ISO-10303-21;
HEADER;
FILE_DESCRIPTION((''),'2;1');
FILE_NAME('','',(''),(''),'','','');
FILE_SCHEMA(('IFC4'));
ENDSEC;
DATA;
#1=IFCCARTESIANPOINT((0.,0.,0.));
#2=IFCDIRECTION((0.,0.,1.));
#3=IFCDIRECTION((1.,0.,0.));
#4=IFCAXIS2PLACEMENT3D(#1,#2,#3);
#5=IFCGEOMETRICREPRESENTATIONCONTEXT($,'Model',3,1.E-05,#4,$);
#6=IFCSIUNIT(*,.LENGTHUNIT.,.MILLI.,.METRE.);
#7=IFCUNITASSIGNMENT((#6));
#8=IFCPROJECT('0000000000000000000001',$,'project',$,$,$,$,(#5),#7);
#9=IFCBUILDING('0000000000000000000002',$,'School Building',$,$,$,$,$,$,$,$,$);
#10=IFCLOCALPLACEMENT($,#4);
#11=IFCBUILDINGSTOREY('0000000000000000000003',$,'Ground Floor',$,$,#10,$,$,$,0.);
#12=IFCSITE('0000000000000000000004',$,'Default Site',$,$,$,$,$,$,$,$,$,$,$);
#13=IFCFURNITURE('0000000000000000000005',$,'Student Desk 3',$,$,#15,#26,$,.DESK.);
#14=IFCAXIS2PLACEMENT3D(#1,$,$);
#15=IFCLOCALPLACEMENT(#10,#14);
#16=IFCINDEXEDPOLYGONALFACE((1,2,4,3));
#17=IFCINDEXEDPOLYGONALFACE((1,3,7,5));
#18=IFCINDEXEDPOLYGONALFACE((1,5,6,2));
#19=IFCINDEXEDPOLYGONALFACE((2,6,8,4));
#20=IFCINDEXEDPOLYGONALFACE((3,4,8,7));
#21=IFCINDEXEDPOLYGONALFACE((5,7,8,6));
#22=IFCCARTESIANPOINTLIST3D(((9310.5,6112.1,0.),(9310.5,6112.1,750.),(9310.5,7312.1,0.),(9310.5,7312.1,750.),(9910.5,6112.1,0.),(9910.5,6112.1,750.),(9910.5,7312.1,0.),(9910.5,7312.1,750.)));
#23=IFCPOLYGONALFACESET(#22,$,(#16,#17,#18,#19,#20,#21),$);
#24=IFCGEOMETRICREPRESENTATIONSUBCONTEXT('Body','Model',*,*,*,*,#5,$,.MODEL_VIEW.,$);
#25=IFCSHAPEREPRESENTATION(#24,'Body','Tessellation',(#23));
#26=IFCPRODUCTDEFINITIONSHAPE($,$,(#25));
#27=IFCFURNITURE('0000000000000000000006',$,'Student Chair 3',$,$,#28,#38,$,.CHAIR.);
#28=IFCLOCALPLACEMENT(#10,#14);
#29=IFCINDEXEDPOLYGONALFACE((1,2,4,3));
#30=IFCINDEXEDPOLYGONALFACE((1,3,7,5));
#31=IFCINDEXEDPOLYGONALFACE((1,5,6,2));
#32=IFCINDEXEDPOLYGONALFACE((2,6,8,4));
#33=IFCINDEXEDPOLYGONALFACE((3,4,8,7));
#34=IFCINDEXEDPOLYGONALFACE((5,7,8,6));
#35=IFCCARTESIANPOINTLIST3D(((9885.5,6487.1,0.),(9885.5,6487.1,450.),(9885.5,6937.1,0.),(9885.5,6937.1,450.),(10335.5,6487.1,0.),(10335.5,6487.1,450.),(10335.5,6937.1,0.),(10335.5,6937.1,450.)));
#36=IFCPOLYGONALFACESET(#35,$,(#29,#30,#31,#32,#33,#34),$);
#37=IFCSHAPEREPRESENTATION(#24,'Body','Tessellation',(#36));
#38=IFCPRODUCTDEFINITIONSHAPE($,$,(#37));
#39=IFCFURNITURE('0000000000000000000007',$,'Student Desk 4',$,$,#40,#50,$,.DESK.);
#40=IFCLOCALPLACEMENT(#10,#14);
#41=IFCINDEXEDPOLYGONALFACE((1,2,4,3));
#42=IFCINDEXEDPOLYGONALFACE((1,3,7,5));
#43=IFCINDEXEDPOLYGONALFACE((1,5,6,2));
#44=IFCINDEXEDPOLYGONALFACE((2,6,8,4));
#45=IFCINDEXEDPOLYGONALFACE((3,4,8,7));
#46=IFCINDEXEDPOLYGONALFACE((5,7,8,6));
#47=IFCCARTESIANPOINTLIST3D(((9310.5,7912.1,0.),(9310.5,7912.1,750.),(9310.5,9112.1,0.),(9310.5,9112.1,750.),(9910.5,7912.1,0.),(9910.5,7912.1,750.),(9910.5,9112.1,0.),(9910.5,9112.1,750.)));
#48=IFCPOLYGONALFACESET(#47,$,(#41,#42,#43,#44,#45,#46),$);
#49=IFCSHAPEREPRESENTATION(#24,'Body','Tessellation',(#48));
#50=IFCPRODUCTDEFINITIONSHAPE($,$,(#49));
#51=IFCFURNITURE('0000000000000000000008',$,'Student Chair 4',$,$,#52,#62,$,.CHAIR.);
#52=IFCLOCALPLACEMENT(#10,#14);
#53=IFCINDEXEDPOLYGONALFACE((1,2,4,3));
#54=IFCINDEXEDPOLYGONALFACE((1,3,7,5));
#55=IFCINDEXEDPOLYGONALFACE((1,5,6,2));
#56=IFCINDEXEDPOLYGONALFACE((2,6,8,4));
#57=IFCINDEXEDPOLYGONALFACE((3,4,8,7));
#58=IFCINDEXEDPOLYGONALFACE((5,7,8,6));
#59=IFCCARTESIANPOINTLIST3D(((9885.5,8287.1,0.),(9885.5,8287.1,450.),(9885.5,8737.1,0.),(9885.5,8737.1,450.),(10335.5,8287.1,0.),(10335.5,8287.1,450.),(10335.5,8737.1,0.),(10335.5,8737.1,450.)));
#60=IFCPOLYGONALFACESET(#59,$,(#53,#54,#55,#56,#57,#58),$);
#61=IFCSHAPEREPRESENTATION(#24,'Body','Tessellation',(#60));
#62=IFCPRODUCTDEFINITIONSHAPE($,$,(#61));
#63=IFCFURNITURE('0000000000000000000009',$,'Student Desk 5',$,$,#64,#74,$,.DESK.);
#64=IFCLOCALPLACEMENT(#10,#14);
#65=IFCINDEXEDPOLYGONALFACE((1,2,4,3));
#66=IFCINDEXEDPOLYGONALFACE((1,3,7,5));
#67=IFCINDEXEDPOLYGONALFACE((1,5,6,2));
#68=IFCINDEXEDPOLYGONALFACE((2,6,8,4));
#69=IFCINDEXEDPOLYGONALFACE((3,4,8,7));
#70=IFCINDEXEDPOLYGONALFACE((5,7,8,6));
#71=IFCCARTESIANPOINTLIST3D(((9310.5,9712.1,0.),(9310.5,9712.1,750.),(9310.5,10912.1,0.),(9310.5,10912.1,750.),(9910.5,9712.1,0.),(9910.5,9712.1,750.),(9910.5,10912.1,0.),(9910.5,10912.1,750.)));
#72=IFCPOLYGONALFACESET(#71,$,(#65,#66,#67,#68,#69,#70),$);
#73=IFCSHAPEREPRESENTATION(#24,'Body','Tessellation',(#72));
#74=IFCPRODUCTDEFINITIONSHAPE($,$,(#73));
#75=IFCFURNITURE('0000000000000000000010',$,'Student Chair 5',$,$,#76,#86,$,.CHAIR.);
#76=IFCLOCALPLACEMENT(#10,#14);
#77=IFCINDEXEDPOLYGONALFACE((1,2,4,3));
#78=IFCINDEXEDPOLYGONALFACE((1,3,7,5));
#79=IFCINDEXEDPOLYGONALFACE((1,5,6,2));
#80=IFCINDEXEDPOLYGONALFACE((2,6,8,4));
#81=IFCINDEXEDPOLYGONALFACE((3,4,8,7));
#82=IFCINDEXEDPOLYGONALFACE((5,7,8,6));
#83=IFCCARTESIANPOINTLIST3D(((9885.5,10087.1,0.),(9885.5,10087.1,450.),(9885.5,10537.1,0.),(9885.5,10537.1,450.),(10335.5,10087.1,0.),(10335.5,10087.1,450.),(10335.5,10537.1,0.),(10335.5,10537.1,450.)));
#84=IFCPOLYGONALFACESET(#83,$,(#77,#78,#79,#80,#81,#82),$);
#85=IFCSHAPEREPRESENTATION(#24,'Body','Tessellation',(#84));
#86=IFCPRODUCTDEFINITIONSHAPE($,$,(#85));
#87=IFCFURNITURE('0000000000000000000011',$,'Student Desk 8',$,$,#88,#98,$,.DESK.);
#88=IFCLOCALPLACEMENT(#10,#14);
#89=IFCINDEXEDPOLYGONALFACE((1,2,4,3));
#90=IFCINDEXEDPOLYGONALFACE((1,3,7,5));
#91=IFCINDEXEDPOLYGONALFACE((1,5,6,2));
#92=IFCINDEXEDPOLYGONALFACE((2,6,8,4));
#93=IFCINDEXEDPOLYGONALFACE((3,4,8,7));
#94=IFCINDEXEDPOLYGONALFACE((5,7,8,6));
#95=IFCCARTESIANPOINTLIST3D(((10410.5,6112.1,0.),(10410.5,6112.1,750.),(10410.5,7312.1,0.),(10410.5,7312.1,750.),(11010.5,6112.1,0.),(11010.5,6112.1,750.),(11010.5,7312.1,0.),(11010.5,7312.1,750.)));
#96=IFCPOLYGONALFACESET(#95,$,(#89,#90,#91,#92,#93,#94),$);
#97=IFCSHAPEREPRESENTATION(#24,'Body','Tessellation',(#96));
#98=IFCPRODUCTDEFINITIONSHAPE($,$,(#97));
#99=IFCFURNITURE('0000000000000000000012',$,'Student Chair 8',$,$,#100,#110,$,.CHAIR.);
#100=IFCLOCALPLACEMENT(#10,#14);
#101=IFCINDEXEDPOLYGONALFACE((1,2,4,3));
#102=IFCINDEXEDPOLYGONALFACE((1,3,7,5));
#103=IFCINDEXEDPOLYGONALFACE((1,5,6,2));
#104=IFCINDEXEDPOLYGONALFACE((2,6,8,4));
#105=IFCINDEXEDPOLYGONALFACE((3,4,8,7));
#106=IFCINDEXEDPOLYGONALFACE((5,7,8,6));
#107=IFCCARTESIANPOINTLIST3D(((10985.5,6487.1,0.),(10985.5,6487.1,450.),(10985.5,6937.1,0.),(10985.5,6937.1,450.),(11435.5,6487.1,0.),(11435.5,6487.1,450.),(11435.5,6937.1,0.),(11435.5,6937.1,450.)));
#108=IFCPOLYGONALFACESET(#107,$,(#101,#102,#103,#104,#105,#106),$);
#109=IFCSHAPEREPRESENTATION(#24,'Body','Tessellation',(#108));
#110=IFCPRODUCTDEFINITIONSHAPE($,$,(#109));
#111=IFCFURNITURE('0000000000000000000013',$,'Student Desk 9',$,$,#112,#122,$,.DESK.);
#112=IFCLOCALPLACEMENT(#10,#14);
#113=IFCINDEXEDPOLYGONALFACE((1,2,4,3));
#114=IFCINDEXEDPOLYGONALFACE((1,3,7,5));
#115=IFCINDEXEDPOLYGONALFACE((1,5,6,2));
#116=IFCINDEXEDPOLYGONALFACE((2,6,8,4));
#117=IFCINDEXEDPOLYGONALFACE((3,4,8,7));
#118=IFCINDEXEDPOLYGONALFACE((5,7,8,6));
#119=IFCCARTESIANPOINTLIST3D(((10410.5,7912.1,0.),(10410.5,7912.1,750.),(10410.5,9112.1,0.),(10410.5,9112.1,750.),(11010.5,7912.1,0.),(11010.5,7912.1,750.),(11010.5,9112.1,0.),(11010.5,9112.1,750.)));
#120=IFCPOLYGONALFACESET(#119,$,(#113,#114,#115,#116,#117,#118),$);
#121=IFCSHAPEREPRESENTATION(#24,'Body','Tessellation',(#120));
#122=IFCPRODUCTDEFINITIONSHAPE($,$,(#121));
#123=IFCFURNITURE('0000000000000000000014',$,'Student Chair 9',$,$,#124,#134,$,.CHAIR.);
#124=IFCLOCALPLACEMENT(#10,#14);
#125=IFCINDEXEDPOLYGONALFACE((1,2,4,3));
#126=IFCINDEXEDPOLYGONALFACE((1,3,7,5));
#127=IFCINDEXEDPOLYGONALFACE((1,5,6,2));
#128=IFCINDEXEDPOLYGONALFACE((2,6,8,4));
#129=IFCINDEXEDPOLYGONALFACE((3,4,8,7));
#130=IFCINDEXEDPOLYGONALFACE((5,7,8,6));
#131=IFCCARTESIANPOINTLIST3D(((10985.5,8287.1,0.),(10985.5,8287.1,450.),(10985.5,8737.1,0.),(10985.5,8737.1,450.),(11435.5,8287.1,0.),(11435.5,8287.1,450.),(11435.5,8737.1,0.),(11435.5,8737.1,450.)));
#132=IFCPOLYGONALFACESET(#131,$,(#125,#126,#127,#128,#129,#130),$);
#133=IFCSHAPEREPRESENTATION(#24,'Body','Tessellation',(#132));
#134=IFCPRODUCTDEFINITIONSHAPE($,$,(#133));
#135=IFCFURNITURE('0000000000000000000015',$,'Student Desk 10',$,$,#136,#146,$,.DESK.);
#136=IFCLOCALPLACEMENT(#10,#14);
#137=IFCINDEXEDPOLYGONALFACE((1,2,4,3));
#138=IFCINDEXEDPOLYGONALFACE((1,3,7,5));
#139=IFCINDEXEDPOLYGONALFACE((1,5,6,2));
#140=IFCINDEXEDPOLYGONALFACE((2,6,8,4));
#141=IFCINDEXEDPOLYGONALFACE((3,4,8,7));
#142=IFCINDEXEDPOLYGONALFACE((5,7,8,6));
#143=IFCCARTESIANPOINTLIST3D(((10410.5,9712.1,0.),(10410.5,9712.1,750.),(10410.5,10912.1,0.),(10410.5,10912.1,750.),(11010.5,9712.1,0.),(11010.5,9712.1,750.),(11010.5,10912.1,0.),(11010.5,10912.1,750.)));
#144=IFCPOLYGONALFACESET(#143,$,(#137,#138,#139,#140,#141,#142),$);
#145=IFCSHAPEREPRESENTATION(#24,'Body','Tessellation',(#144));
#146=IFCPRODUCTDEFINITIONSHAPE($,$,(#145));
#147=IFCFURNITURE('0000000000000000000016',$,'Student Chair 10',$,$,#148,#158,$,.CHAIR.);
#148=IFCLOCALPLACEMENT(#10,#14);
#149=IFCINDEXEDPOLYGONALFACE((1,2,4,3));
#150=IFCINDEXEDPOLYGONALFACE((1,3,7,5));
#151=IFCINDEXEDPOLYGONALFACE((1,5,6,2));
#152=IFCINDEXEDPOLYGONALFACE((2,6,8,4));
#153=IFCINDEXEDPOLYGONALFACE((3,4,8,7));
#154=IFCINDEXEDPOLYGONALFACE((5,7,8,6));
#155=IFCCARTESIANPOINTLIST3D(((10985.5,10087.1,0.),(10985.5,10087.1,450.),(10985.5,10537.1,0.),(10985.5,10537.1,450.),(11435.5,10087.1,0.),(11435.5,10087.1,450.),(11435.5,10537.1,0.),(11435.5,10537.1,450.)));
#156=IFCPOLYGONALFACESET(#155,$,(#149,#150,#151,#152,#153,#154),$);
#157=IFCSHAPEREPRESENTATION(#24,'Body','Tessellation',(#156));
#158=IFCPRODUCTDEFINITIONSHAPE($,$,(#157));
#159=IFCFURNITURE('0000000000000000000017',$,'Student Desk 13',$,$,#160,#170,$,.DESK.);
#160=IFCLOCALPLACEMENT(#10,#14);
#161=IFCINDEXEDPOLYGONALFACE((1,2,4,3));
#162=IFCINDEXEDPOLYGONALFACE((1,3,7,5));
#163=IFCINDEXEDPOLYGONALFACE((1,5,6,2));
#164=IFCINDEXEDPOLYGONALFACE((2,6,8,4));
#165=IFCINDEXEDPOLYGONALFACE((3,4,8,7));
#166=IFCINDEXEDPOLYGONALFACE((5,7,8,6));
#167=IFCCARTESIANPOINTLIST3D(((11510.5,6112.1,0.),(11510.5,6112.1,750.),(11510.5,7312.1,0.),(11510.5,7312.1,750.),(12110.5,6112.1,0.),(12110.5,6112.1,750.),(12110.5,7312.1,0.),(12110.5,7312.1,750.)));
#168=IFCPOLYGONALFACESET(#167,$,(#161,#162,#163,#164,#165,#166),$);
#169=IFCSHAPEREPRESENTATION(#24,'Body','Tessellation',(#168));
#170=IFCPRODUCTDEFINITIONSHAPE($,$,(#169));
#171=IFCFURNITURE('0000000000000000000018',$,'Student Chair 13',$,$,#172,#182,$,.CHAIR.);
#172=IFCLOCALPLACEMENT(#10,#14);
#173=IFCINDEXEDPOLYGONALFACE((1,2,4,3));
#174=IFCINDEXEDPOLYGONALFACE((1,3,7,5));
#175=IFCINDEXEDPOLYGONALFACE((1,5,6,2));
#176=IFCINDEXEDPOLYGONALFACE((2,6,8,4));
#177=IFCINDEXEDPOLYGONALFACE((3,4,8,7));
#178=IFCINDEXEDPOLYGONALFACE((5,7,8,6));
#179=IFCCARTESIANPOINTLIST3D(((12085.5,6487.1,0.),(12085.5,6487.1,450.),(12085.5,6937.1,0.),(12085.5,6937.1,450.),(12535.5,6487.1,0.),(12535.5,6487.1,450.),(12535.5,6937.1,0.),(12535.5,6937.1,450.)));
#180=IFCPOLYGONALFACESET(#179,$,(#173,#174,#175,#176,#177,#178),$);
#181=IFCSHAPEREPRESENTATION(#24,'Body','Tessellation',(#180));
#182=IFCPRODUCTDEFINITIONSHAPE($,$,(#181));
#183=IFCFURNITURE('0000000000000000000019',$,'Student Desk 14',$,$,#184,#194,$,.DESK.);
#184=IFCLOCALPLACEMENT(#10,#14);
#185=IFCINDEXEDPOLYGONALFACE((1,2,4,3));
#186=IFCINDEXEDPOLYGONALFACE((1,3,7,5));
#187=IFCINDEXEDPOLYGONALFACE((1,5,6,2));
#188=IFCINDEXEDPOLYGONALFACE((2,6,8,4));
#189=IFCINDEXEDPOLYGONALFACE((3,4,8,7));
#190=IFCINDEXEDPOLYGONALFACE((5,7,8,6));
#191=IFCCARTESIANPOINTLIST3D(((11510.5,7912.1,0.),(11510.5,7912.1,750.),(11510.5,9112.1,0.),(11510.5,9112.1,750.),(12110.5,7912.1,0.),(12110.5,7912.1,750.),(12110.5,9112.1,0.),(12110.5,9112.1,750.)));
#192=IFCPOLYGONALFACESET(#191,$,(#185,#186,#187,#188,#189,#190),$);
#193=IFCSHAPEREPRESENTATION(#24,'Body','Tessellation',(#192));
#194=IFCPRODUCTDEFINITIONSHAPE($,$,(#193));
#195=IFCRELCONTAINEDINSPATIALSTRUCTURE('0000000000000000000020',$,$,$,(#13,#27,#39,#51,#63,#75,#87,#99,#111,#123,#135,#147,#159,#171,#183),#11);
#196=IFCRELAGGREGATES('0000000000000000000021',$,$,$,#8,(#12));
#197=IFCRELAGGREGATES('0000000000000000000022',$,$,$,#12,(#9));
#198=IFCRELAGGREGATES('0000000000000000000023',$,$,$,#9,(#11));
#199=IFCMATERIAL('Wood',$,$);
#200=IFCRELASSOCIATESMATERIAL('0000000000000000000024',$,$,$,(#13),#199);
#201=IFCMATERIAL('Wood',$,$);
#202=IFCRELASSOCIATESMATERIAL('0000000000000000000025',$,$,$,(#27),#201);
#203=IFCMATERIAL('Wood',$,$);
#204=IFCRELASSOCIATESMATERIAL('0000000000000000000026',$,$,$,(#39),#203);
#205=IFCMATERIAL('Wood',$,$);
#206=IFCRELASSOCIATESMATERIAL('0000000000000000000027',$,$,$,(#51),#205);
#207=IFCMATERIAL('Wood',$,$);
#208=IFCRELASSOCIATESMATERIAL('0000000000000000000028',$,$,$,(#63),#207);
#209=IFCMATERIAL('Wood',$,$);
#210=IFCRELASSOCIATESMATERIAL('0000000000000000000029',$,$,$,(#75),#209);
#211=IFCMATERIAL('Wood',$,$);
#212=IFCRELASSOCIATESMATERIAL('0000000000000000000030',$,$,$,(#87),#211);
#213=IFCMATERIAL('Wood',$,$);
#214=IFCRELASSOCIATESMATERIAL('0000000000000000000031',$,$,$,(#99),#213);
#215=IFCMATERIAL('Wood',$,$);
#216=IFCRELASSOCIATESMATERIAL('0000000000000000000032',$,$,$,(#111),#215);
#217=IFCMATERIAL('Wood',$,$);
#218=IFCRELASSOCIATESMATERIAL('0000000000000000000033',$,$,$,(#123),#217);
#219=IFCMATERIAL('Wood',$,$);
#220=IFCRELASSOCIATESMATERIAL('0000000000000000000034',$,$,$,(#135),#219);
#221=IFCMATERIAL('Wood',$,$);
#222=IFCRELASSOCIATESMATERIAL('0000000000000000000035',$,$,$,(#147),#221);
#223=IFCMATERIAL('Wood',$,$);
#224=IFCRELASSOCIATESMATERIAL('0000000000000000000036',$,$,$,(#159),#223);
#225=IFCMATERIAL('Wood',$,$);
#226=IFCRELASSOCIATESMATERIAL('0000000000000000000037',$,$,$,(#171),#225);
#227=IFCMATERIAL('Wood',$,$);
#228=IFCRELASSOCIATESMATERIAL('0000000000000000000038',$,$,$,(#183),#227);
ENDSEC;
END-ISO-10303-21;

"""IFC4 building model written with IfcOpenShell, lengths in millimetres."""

from ifc_helpers import new_model, si_unit, frame, origin_with_axes, origin_2d, place, context, subcontext, project, spatial, rectangle, extrude, material, element, save


model = new_model("IFC4")

# Units and contexts
model_context = context("Model", 3, precision=1e-05, world=origin_with_axes())
body_context = subcontext(model_context, "Body", "Model", "MODEL_VIEW")
ifc_project = project(units=[si_unit("LENGTHUNIT", "METRE", prefix="MILLI")], contexts=[model_context])

# Site, building, storey
site = spatial("IfcSite", under=ifc_project, Name="Default Site")
building = spatial("IfcBuilding", under=site, Name="School Building")
storey_placement = place(None, origin_with_axes())
storey = spatial("IfcBuildingStorey", under=building, at=storey_placement, Name="Ground Floor", Elevation=0.0)

# Furniture
ifc_material_1 = material(Name="Wood")
furniture_1_placement = place(storey_placement, frame((9610.5, 6712.1, 0.0), z_axis=(0.0, 0.0, 1.0), x_axis=(0.0, 1.0, 0.0)))
element("IfcFurniture", 1, at=furniture_1_placement, inside=storey, material=ifc_material_1, Name="Student Desk 3", PredefinedType="DESK", context=body_context, shape_type="SweptSolid", body=[
    extrude(rectangle(XDim=1200.0, YDim=600.0, at=origin_2d()), origin_with_axes(), (0.0, 0.0, 1.0), 750.0),
])
ifc_material_2 = material(Name="Wood")
furniture_2_placement = place(storey_placement, frame((10110.5, 6712.1, 0.0), z_axis=(0.0, 0.0, 1.0), x_axis=(1.0, 0.0, 0.0)))
element("IfcFurniture", 2, at=furniture_2_placement, inside=storey, material=ifc_material_2, Name="Student Chair 3", PredefinedType="CHAIR", context=body_context, shape_type="SweptSolid", body=[
    extrude(rectangle(XDim=450.0, YDim=450.0, at=origin_2d()), origin_with_axes(), (0.0, 0.0, 1.0), 450.0),
])
ifc_material_3 = material(Name="Wood")
furniture_3_placement = place(storey_placement, frame((9610.5, 8512.1, 0.0), z_axis=(0.0, 0.0, 1.0), x_axis=(0.0, 1.0, 0.0)))
element("IfcFurniture", 3, at=furniture_3_placement, inside=storey, material=ifc_material_3, Name="Student Desk 4", PredefinedType="DESK", context=body_context, shape_type="SweptSolid", body=[
    extrude(rectangle(XDim=1200.0, YDim=600.0, at=origin_2d()), origin_with_axes(), (0.0, 0.0, 1.0), 750.0),
])
ifc_material_4 = material(Name="Wood")
furniture_4_placement = place(storey_placement, frame((10110.5, 8512.1, 0.0), z_axis=(0.0, 0.0, 1.0), x_axis=(1.0, 0.0, 0.0)))
element("IfcFurniture", 4, at=furniture_4_placement, inside=storey, material=ifc_material_4, Name="Student Chair 4", PredefinedType="CHAIR", context=body_context, shape_type="SweptSolid", body=[
    extrude(rectangle(XDim=450.0, YDim=450.0, at=origin_2d()), origin_with_axes(), (0.0, 0.0, 1.0), 450.0),
])
ifc_material_5 = material(Name="Wood")
furniture_5_placement = place(storey_placement, frame((9610.5, 10312.1, 0.0), z_axis=(0.0, 0.0, 1.0), x_axis=(0.0, 1.0, 0.0)))
element("IfcFurniture", 5, at=furniture_5_placement, inside=storey, material=ifc_material_5, Name="Student Desk 5", PredefinedType="DESK", context=body_context, shape_type="SweptSolid", body=[
    extrude(rectangle(XDim=1200.0, YDim=600.0, at=origin_2d()), origin_with_axes(), (0.0, 0.0, 1.0), 750.0),
])
ifc_material_6 = material(Name="Wood")
furniture_6_placement = place(storey_placement, frame((10110.5, 10312.1, 0.0), z_axis=(0.0, 0.0, 1.0), x_axis=(1.0, 0.0, 0.0)))
element("IfcFurniture", 6, at=furniture_6_placement, inside=storey, material=ifc_material_6, Name="Student Chair 5", PredefinedType="CHAIR", context=body_context, shape_type="SweptSolid", body=[
    extrude(rectangle(XDim=450.0, YDim=450.0, at=origin_2d()), origin_with_axes(), (0.0, 0.0, 1.0), 450.0),
])
ifc_material_7 = material(Name="Wood")
furniture_7_placement = place(storey_placement, frame((10710.5, 6712.1, 0.0), z_axis=(0.0, 0.0, 1.0), x_axis=(0.0, 1.0, 0.0)))
element("IfcFurniture", 7, at=furniture_7_placement, inside=storey, material=ifc_material_7, Name="Student Desk 8", PredefinedType="DESK", context=body_context, shape_type="SweptSolid", body=[
    extrude(rectangle(XDim=1200.0, YDim=600.0, at=origin_2d()), origin_with_axes(), (0.0, 0.0, 1.0), 750.0),
])
ifc_material_8 = material(Name="Wood")
furniture_8_placement = place(storey_placement, frame((11210.5, 6712.1, 0.0), z_axis=(0.0, 0.0, 1.0), x_axis=(1.0, 0.0, 0.0)))
element("IfcFurniture", 8, at=furniture_8_placement, inside=storey, material=ifc_material_8, Name="Student Chair 8", PredefinedType="CHAIR", context=body_context, shape_type="SweptSolid", body=[
    extrude(rectangle(XDim=450.0, YDim=450.0, at=origin_2d()), origin_with_axes(), (0.0, 0.0, 1.0), 450.0),
])
ifc_material_9 = material(Name="Wood")
furniture_9_placement = place(storey_placement, frame((10710.5, 8512.1, 0.0), z_axis=(0.0, 0.0, 1.0), x_axis=(0.0, 1.0, 0.0)))
element("IfcFurniture", 9, at=furniture_9_placement, inside=storey, material=ifc_material_9, Name="Student Desk 9", PredefinedType="DESK", context=body_context, shape_type="SweptSolid", body=[
    extrude(rectangle(XDim=1200.0, YDim=600.0, at=origin_2d()), origin_with_axes(), (0.0, 0.0, 1.0), 750.0),
])
ifc_material_10 = material(Name="Wood")
furniture_10_placement = place(storey_placement, frame((11210.5, 8512.1, 0.0), z_axis=(0.0, 0.0, 1.0), x_axis=(1.0, 0.0, 0.0)))
element("IfcFurniture", 10, at=furniture_10_placement, inside=storey, material=ifc_material_10, Name="Student Chair 9", PredefinedType="CHAIR", context=body_context, shape_type="SweptSolid", body=[
    extrude(rectangle(XDim=450.0, YDim=450.0, at=origin_2d()), origin_with_axes(), (0.0, 0.0, 1.0), 450.0),
])
ifc_material_11 = material(Name="Wood")
furniture_11_placement = place(storey_placement, frame((10710.5, 10312.1, 0.0), z_axis=(0.0, 0.0, 1.0), x_axis=(0.0, 1.0, 0.0)))
element("IfcFurniture", 11, at=furniture_11_placement, inside=storey, material=ifc_material_11, Name="Student Desk 10", PredefinedType="DESK", context=body_context, shape_type="SweptSolid", body=[
    extrude(rectangle(XDim=1200.0, YDim=600.0, at=origin_2d()), origin_with_axes(), (0.0, 0.0, 1.0), 750.0),
])
ifc_material_12 = material(Name="Wood")
furniture_12_placement = place(storey_placement, frame((11210.5, 10312.1, 0.0), z_axis=(0.0, 0.0, 1.0), x_axis=(1.0, 0.0, 0.0)))
element("IfcFurniture", 12, at=furniture_12_placement, inside=storey, material=ifc_material_12, Name="Student Chair 10", PredefinedType="CHAIR", context=body_context, shape_type="SweptSolid", body=[
    extrude(rectangle(XDim=450.0, YDim=450.0, at=origin_2d()), origin_with_axes(), (0.0, 0.0, 1.0), 450.0),
])
ifc_material_13 = material(Name="Wood")
furniture_13_placement = place(storey_placement, frame((11810.5, 6712.1, 0.0), z_axis=(0.0, 0.0, 1.0), x_axis=(0.0, 1.0, 0.0)))
element("IfcFurniture", 13, at=furniture_13_placement, inside=storey, material=ifc_material_13, Name="Student Desk 13", PredefinedType="DESK", context=body_context, shape_type="SweptSolid", body=[
    extrude(rectangle(XDim=1200.0, YDim=600.0, at=origin_2d()), origin_with_axes(), (0.0, 0.0, 1.0), 750.0),
])
ifc_material_14 = material(Name="Wood")
furniture_14_placement = place(storey_placement, frame((12310.5, 6712.1, 0.0), z_axis=(0.0, 0.0, 1.0), x_axis=(1.0, 0.0, 0.0)))
element("IfcFurniture", 14, at=furniture_14_placement, inside=storey, material=ifc_material_14, Name="Student Chair 13", PredefinedType="CHAIR", context=body_context, shape_type="SweptSolid", body=[
    extrude(rectangle(XDim=450.0, YDim=450.0, at=origin_2d()), origin_with_axes(), (0.0, 0.0, 1.0), 450.0),
])
ifc_material_15 = material(Name="Wood")
furniture_15_placement = place(storey_placement, frame((11810.5, 8512.1, 0.0), z_axis=(0.0, 0.0, 1.0), x_axis=(0.0, 1.0, 0.0)))
element("IfcFurniture", 15, at=furniture_15_placement, inside=storey, material=ifc_material_15, Name="Student Desk 14", PredefinedType="DESK", context=body_context, shape_type="SweptSolid", body=[
    extrude(rectangle(XDim=1200.0, YDim=600.0, at=origin_2d()), origin_with_axes(), (0.0, 0.0, 1.0), 750.0),
])

save(model, "model.ifc")
